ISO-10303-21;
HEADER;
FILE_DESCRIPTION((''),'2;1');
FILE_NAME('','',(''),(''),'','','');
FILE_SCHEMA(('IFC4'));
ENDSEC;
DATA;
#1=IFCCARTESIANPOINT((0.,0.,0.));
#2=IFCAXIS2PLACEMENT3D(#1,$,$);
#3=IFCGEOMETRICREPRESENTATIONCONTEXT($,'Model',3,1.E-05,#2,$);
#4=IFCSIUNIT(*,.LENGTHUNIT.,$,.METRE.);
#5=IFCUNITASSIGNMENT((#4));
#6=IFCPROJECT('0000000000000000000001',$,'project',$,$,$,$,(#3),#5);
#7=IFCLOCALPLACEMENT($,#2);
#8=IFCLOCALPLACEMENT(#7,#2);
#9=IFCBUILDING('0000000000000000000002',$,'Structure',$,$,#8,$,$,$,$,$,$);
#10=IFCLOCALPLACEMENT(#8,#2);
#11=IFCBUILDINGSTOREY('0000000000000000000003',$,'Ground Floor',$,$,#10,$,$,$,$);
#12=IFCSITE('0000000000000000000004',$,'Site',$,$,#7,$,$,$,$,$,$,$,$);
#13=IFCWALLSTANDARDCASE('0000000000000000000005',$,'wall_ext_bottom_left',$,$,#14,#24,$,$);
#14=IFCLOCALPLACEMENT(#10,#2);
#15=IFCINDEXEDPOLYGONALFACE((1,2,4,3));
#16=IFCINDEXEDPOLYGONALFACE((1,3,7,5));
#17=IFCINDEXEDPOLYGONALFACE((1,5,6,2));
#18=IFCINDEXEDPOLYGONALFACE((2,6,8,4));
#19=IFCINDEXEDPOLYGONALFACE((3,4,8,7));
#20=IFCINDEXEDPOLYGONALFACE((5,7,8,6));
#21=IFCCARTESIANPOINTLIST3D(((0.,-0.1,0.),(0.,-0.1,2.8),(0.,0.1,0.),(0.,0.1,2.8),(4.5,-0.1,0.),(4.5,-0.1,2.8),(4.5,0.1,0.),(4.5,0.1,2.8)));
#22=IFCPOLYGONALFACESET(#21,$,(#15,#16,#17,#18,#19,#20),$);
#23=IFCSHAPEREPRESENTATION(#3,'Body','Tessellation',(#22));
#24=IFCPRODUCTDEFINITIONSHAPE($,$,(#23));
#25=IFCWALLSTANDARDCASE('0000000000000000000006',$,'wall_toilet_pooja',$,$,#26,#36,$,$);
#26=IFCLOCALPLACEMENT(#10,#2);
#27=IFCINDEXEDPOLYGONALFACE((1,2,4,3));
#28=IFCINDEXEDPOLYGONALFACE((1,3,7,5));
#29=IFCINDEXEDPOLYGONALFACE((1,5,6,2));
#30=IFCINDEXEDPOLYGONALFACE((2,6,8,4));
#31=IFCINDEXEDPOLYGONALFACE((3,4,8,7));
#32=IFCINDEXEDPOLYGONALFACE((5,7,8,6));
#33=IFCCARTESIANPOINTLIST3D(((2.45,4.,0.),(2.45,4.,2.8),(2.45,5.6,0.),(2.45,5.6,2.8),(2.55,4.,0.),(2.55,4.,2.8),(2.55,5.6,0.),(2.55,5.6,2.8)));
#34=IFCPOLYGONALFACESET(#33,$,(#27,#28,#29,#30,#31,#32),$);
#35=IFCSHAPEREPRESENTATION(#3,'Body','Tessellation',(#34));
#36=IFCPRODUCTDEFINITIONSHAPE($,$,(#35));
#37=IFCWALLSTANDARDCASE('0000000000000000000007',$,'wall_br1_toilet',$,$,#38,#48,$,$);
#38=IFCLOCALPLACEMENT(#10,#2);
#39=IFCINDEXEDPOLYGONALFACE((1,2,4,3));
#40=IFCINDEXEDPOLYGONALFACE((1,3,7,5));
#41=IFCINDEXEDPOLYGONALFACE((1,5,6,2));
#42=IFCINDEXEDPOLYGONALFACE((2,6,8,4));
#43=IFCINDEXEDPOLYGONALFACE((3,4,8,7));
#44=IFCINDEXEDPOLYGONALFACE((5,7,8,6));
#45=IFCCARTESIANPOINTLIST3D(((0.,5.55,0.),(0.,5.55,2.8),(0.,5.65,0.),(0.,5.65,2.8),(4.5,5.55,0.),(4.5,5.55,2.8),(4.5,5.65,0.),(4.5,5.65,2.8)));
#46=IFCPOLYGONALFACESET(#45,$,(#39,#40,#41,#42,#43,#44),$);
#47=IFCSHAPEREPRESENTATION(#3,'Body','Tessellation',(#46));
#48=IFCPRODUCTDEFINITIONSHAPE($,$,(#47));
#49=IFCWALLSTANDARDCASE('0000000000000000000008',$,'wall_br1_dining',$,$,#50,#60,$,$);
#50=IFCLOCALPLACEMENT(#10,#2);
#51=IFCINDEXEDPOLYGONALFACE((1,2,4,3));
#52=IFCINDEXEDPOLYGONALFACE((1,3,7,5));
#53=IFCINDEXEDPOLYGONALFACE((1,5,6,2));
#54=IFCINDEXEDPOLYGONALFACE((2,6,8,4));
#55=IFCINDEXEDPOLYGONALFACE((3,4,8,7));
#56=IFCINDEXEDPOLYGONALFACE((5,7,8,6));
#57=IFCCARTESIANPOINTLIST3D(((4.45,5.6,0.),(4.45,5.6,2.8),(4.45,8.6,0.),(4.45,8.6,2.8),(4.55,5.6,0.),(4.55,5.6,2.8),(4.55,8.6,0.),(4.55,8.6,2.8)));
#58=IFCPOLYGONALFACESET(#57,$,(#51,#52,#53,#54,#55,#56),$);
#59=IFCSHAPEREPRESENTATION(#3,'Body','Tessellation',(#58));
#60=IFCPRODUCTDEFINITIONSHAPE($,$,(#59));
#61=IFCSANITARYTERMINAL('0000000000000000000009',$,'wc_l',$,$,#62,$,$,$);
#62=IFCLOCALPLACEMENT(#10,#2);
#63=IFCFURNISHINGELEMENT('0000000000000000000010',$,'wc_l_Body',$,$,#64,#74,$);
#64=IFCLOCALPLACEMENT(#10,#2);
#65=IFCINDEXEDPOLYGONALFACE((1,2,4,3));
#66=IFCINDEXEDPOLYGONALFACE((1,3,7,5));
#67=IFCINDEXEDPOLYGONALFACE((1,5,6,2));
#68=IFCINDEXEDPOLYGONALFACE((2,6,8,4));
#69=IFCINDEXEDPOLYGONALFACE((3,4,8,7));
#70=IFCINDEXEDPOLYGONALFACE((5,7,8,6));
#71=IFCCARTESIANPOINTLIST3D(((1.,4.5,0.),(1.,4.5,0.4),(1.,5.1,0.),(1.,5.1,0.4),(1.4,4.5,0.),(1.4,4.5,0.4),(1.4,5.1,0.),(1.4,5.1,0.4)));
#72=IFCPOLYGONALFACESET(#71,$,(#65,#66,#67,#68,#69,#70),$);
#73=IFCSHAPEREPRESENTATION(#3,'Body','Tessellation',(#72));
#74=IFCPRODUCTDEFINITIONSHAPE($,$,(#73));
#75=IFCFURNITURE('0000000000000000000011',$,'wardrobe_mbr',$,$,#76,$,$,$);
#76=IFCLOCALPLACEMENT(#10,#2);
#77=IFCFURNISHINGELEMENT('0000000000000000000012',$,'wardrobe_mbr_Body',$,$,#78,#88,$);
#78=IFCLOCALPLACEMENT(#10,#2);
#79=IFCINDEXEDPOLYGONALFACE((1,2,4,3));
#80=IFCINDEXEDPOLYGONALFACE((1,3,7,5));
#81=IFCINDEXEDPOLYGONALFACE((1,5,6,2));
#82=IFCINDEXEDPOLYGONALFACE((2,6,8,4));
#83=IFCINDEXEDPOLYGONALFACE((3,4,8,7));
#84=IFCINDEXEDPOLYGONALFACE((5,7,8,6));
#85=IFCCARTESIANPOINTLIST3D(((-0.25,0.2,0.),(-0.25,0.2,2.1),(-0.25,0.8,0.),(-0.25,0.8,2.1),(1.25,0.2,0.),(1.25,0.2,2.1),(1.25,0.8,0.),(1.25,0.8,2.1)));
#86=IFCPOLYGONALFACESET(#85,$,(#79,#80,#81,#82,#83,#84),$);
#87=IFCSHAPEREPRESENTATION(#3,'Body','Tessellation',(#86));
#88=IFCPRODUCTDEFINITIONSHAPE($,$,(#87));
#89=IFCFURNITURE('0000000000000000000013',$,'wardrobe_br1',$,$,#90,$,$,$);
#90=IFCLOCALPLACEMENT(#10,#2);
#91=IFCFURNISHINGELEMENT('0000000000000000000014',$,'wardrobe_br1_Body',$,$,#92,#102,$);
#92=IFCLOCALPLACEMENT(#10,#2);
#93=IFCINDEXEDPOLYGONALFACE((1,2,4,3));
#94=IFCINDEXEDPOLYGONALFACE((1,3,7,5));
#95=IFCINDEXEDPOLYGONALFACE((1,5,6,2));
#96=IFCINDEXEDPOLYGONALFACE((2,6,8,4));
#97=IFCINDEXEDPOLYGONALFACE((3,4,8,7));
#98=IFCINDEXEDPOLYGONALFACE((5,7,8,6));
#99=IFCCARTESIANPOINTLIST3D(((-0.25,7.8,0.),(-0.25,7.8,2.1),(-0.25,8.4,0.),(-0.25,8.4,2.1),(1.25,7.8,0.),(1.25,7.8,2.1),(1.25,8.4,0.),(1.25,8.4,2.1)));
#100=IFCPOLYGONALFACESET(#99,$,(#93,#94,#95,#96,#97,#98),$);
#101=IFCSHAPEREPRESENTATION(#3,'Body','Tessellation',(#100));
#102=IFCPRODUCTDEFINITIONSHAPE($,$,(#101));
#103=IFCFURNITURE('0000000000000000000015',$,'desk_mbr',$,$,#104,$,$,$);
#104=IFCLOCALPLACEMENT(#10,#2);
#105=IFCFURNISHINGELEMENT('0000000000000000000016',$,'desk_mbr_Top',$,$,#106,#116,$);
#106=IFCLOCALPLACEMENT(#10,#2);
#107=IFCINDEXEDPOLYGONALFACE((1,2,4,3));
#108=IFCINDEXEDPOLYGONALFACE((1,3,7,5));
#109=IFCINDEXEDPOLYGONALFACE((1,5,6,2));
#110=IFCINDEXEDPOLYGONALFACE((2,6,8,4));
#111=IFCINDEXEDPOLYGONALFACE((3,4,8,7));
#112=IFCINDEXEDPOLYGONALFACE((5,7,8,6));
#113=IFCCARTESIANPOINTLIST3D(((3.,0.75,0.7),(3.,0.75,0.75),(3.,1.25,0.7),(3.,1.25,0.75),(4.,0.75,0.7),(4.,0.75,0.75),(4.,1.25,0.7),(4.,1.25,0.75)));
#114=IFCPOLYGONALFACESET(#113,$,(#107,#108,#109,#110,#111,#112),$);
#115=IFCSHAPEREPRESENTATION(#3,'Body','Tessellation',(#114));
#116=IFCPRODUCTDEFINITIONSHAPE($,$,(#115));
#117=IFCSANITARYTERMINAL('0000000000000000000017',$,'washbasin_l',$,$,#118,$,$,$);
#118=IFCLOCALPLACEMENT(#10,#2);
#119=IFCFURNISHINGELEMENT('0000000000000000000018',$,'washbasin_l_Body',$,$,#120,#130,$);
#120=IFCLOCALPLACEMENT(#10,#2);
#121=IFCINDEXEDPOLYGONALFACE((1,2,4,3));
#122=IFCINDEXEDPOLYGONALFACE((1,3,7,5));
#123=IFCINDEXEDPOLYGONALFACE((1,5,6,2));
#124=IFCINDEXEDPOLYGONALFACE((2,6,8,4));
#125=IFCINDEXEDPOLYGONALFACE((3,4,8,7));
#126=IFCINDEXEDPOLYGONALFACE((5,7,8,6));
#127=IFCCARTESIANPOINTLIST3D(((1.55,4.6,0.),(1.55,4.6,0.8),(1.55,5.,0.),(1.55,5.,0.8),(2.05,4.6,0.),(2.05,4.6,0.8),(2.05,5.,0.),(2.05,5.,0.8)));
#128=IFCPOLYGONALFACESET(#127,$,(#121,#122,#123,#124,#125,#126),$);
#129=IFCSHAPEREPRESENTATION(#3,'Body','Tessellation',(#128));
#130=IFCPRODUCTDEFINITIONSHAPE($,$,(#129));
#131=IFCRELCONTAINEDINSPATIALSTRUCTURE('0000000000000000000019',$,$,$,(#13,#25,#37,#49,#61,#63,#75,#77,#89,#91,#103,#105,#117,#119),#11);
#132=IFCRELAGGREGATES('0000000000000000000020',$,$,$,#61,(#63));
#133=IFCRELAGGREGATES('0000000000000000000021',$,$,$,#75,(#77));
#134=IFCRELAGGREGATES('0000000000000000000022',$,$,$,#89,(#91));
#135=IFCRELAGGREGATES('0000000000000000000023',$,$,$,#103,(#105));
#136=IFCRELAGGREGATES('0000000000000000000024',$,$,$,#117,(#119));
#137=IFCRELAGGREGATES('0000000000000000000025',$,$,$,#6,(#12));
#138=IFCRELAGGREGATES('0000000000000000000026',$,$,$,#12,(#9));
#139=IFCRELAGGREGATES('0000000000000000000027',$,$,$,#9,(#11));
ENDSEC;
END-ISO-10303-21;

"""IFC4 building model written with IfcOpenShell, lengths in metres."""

from ifc_helpers import new_model, si_unit, frame, origin, origin_2d, place, context, project, spatial, rectangle, extrude, element, aggregate, save


model = new_model("IFC4")

# Units and contexts
model_context = context("Model", 3, precision=1e-05, world=origin())
ifc_project = project(units=[si_unit("LENGTHUNIT", "METRE")], contexts=[model_context])

# Site, building, storey
site_placement = place(None, origin())
site = spatial("IfcSite", under=ifc_project, at=site_placement, Name="Site")
building_placement = place(site_placement, origin())
building = spatial("IfcBuilding", under=site, at=building_placement, Name="Structure")
storey_placement = place(building_placement, origin())
storey = spatial("IfcBuildingStorey", under=building, at=storey_placement, Name="Ground Floor")

# Walls
wall_1_placement = place(storey_placement, frame((0.0, 0.0, 0.0), x_axis=(1.0, 0.0, 0.0)))
element("IfcWallStandardCase", 1, at=wall_1_placement, inside=storey, Name="wall_ext_bottom_left", context=model_context, shape_type="SweptSolid", body=[
    extrude(rectangle(XDim=4.5, YDim=0.2, at=origin_2d()), frame((2.25, 0.0, 0.0)), (0.0, 0.0, 1.0), 2.8),
])
wall_2_placement = place(storey_placement, frame((2.5, 4.0, 0.0), x_axis=(0.0, 1.0, 0.0)))
element("IfcWallStandardCase", 2, at=wall_2_placement, inside=storey, Name="wall_toilet_pooja", context=model_context, shape_type="SweptSolid", body=[
    extrude(rectangle(XDim=1.6, YDim=0.1, at=origin_2d()), frame((0.8, 0.0, 0.0)), (0.0, 0.0, 1.0), 2.8),
])
wall_3_placement = place(storey_placement, frame((0.0, 5.6, 0.0), x_axis=(1.0, 0.0, 0.0)))
element("IfcWallStandardCase", 3, at=wall_3_placement, inside=storey, Name="wall_br1_toilet", context=model_context, shape_type="SweptSolid", body=[
    extrude(rectangle(XDim=4.5, YDim=0.1, at=origin_2d()), frame((2.25, 0.0, 0.0)), (0.0, 0.0, 1.0), 2.8),
])
wall_4_placement = place(storey_placement, frame((4.5, 5.6, 0.0), x_axis=(0.0, 1.0, 0.0)))
element("IfcWallStandardCase", 4, at=wall_4_placement, inside=storey, Name="wall_br1_dining", context=model_context, shape_type="SweptSolid", body=[
    extrude(rectangle(XDim=3.0, YDim=0.1, at=origin_2d()), frame((1.5, 0.0, 0.0)), (0.0, 0.0, 1.0), 2.8),
])

# Sanitary terminal, furnishing element
sanitary_terminal_1_placement = place(storey_placement, frame((1.2, 4.8, 0.0)))
sanitary_terminal_1 = element("IfcSanitaryTerminal", 5, at=sanitary_terminal_1_placement, inside=storey, Name="wc_l")
furnishing_1_placement = place(sanitary_terminal_1_placement, origin())
furnishing_1 = element("IfcFurnishingElement", 6, at=furnishing_1_placement, inside=storey, Name="wc_l_Body", context=model_context, shape_type="SweptSolid", body=[
    extrude(rectangle(XDim=0.4, YDim=0.6, at=origin_2d()), origin(), (0.0, 0.0, 1.0), 0.4),
])
aggregate(sanitary_terminal_1, [furnishing_1])

# Furniture, furnishing elements
furniture_1_placement = place(storey_placement, frame((0.5, 0.5, 0.0)))
furniture_1 = element("IfcFurniture", 7, at=furniture_1_placement, inside=storey, Name="wardrobe_mbr")
furnishing_2_placement = place(furniture_1_placement, origin())
furnishing_2 = element("IfcFurnishingElement", 8, at=furnishing_2_placement, inside=storey, Name="wardrobe_mbr_Body", context=model_context, shape_type="SweptSolid", body=[
    extrude(rectangle(XDim=1.5, YDim=0.6, at=origin_2d()), origin(), (0.0, 0.0, 1.0), 2.1),
])
aggregate(furniture_1, [furnishing_2])
furniture_2_placement = place(storey_placement, frame((0.5, 8.1, 0.0)))
furniture_2 = element("IfcFurniture", 9, at=furniture_2_placement, inside=storey, Name="wardrobe_br1")
furnishing_3_placement = place(furniture_2_placement, origin())
furnishing_3 = element("IfcFurnishingElement", 10, at=furnishing_3_placement, inside=storey, Name="wardrobe_br1_Body", context=model_context, shape_type="SweptSolid", body=[
    extrude(rectangle(XDim=1.5, YDim=0.6, at=origin_2d()), origin(), (0.0, 0.0, 1.0), 2.1),
])
aggregate(furniture_2, [furnishing_3])

# Furniture, furnishing element
furniture_3_placement = place(storey_placement, frame((3.5, 1.0, 0.0)))
furniture_3 = element("IfcFurniture", 11, at=furniture_3_placement, inside=storey, Name="desk_mbr")
furnishing_4_placement = place(furniture_3_placement, origin())
furnishing_4 = element("IfcFurnishingElement", 12, at=furnishing_4_placement, inside=storey, Name="desk_mbr_Top", context=model_context, shape_type="SweptSolid", body=[
    extrude(rectangle(XDim=1.0, YDim=0.5, at=origin_2d()), frame((0.0, 0.0, 0.7)), (0.0, 0.0, 1.0), 0.05),
])
aggregate(furniture_3, [furnishing_4])

# Sanitary terminal, furnishing element
sanitary_terminal_2_placement = place(storey_placement, frame((1.8, 4.8, 0.0)))
sanitary_terminal_2 = element("IfcSanitaryTerminal", 13, at=sanitary_terminal_2_placement, inside=storey, Name="washbasin_l")
furnishing_5_placement = place(sanitary_terminal_2_placement, origin())
furnishing_5 = element("IfcFurnishingElement", 14, at=furnishing_5_placement, inside=storey, Name="washbasin_l_Body", context=model_context, shape_type="SweptSolid", body=[
    extrude(rectangle(XDim=0.5, YDim=0.4, at=origin_2d()), origin(), (0.0, 0.0, 1.0), 0.8),
])
aggregate(sanitary_terminal_2, [furnishing_5])

save(model, "model.ifc")
